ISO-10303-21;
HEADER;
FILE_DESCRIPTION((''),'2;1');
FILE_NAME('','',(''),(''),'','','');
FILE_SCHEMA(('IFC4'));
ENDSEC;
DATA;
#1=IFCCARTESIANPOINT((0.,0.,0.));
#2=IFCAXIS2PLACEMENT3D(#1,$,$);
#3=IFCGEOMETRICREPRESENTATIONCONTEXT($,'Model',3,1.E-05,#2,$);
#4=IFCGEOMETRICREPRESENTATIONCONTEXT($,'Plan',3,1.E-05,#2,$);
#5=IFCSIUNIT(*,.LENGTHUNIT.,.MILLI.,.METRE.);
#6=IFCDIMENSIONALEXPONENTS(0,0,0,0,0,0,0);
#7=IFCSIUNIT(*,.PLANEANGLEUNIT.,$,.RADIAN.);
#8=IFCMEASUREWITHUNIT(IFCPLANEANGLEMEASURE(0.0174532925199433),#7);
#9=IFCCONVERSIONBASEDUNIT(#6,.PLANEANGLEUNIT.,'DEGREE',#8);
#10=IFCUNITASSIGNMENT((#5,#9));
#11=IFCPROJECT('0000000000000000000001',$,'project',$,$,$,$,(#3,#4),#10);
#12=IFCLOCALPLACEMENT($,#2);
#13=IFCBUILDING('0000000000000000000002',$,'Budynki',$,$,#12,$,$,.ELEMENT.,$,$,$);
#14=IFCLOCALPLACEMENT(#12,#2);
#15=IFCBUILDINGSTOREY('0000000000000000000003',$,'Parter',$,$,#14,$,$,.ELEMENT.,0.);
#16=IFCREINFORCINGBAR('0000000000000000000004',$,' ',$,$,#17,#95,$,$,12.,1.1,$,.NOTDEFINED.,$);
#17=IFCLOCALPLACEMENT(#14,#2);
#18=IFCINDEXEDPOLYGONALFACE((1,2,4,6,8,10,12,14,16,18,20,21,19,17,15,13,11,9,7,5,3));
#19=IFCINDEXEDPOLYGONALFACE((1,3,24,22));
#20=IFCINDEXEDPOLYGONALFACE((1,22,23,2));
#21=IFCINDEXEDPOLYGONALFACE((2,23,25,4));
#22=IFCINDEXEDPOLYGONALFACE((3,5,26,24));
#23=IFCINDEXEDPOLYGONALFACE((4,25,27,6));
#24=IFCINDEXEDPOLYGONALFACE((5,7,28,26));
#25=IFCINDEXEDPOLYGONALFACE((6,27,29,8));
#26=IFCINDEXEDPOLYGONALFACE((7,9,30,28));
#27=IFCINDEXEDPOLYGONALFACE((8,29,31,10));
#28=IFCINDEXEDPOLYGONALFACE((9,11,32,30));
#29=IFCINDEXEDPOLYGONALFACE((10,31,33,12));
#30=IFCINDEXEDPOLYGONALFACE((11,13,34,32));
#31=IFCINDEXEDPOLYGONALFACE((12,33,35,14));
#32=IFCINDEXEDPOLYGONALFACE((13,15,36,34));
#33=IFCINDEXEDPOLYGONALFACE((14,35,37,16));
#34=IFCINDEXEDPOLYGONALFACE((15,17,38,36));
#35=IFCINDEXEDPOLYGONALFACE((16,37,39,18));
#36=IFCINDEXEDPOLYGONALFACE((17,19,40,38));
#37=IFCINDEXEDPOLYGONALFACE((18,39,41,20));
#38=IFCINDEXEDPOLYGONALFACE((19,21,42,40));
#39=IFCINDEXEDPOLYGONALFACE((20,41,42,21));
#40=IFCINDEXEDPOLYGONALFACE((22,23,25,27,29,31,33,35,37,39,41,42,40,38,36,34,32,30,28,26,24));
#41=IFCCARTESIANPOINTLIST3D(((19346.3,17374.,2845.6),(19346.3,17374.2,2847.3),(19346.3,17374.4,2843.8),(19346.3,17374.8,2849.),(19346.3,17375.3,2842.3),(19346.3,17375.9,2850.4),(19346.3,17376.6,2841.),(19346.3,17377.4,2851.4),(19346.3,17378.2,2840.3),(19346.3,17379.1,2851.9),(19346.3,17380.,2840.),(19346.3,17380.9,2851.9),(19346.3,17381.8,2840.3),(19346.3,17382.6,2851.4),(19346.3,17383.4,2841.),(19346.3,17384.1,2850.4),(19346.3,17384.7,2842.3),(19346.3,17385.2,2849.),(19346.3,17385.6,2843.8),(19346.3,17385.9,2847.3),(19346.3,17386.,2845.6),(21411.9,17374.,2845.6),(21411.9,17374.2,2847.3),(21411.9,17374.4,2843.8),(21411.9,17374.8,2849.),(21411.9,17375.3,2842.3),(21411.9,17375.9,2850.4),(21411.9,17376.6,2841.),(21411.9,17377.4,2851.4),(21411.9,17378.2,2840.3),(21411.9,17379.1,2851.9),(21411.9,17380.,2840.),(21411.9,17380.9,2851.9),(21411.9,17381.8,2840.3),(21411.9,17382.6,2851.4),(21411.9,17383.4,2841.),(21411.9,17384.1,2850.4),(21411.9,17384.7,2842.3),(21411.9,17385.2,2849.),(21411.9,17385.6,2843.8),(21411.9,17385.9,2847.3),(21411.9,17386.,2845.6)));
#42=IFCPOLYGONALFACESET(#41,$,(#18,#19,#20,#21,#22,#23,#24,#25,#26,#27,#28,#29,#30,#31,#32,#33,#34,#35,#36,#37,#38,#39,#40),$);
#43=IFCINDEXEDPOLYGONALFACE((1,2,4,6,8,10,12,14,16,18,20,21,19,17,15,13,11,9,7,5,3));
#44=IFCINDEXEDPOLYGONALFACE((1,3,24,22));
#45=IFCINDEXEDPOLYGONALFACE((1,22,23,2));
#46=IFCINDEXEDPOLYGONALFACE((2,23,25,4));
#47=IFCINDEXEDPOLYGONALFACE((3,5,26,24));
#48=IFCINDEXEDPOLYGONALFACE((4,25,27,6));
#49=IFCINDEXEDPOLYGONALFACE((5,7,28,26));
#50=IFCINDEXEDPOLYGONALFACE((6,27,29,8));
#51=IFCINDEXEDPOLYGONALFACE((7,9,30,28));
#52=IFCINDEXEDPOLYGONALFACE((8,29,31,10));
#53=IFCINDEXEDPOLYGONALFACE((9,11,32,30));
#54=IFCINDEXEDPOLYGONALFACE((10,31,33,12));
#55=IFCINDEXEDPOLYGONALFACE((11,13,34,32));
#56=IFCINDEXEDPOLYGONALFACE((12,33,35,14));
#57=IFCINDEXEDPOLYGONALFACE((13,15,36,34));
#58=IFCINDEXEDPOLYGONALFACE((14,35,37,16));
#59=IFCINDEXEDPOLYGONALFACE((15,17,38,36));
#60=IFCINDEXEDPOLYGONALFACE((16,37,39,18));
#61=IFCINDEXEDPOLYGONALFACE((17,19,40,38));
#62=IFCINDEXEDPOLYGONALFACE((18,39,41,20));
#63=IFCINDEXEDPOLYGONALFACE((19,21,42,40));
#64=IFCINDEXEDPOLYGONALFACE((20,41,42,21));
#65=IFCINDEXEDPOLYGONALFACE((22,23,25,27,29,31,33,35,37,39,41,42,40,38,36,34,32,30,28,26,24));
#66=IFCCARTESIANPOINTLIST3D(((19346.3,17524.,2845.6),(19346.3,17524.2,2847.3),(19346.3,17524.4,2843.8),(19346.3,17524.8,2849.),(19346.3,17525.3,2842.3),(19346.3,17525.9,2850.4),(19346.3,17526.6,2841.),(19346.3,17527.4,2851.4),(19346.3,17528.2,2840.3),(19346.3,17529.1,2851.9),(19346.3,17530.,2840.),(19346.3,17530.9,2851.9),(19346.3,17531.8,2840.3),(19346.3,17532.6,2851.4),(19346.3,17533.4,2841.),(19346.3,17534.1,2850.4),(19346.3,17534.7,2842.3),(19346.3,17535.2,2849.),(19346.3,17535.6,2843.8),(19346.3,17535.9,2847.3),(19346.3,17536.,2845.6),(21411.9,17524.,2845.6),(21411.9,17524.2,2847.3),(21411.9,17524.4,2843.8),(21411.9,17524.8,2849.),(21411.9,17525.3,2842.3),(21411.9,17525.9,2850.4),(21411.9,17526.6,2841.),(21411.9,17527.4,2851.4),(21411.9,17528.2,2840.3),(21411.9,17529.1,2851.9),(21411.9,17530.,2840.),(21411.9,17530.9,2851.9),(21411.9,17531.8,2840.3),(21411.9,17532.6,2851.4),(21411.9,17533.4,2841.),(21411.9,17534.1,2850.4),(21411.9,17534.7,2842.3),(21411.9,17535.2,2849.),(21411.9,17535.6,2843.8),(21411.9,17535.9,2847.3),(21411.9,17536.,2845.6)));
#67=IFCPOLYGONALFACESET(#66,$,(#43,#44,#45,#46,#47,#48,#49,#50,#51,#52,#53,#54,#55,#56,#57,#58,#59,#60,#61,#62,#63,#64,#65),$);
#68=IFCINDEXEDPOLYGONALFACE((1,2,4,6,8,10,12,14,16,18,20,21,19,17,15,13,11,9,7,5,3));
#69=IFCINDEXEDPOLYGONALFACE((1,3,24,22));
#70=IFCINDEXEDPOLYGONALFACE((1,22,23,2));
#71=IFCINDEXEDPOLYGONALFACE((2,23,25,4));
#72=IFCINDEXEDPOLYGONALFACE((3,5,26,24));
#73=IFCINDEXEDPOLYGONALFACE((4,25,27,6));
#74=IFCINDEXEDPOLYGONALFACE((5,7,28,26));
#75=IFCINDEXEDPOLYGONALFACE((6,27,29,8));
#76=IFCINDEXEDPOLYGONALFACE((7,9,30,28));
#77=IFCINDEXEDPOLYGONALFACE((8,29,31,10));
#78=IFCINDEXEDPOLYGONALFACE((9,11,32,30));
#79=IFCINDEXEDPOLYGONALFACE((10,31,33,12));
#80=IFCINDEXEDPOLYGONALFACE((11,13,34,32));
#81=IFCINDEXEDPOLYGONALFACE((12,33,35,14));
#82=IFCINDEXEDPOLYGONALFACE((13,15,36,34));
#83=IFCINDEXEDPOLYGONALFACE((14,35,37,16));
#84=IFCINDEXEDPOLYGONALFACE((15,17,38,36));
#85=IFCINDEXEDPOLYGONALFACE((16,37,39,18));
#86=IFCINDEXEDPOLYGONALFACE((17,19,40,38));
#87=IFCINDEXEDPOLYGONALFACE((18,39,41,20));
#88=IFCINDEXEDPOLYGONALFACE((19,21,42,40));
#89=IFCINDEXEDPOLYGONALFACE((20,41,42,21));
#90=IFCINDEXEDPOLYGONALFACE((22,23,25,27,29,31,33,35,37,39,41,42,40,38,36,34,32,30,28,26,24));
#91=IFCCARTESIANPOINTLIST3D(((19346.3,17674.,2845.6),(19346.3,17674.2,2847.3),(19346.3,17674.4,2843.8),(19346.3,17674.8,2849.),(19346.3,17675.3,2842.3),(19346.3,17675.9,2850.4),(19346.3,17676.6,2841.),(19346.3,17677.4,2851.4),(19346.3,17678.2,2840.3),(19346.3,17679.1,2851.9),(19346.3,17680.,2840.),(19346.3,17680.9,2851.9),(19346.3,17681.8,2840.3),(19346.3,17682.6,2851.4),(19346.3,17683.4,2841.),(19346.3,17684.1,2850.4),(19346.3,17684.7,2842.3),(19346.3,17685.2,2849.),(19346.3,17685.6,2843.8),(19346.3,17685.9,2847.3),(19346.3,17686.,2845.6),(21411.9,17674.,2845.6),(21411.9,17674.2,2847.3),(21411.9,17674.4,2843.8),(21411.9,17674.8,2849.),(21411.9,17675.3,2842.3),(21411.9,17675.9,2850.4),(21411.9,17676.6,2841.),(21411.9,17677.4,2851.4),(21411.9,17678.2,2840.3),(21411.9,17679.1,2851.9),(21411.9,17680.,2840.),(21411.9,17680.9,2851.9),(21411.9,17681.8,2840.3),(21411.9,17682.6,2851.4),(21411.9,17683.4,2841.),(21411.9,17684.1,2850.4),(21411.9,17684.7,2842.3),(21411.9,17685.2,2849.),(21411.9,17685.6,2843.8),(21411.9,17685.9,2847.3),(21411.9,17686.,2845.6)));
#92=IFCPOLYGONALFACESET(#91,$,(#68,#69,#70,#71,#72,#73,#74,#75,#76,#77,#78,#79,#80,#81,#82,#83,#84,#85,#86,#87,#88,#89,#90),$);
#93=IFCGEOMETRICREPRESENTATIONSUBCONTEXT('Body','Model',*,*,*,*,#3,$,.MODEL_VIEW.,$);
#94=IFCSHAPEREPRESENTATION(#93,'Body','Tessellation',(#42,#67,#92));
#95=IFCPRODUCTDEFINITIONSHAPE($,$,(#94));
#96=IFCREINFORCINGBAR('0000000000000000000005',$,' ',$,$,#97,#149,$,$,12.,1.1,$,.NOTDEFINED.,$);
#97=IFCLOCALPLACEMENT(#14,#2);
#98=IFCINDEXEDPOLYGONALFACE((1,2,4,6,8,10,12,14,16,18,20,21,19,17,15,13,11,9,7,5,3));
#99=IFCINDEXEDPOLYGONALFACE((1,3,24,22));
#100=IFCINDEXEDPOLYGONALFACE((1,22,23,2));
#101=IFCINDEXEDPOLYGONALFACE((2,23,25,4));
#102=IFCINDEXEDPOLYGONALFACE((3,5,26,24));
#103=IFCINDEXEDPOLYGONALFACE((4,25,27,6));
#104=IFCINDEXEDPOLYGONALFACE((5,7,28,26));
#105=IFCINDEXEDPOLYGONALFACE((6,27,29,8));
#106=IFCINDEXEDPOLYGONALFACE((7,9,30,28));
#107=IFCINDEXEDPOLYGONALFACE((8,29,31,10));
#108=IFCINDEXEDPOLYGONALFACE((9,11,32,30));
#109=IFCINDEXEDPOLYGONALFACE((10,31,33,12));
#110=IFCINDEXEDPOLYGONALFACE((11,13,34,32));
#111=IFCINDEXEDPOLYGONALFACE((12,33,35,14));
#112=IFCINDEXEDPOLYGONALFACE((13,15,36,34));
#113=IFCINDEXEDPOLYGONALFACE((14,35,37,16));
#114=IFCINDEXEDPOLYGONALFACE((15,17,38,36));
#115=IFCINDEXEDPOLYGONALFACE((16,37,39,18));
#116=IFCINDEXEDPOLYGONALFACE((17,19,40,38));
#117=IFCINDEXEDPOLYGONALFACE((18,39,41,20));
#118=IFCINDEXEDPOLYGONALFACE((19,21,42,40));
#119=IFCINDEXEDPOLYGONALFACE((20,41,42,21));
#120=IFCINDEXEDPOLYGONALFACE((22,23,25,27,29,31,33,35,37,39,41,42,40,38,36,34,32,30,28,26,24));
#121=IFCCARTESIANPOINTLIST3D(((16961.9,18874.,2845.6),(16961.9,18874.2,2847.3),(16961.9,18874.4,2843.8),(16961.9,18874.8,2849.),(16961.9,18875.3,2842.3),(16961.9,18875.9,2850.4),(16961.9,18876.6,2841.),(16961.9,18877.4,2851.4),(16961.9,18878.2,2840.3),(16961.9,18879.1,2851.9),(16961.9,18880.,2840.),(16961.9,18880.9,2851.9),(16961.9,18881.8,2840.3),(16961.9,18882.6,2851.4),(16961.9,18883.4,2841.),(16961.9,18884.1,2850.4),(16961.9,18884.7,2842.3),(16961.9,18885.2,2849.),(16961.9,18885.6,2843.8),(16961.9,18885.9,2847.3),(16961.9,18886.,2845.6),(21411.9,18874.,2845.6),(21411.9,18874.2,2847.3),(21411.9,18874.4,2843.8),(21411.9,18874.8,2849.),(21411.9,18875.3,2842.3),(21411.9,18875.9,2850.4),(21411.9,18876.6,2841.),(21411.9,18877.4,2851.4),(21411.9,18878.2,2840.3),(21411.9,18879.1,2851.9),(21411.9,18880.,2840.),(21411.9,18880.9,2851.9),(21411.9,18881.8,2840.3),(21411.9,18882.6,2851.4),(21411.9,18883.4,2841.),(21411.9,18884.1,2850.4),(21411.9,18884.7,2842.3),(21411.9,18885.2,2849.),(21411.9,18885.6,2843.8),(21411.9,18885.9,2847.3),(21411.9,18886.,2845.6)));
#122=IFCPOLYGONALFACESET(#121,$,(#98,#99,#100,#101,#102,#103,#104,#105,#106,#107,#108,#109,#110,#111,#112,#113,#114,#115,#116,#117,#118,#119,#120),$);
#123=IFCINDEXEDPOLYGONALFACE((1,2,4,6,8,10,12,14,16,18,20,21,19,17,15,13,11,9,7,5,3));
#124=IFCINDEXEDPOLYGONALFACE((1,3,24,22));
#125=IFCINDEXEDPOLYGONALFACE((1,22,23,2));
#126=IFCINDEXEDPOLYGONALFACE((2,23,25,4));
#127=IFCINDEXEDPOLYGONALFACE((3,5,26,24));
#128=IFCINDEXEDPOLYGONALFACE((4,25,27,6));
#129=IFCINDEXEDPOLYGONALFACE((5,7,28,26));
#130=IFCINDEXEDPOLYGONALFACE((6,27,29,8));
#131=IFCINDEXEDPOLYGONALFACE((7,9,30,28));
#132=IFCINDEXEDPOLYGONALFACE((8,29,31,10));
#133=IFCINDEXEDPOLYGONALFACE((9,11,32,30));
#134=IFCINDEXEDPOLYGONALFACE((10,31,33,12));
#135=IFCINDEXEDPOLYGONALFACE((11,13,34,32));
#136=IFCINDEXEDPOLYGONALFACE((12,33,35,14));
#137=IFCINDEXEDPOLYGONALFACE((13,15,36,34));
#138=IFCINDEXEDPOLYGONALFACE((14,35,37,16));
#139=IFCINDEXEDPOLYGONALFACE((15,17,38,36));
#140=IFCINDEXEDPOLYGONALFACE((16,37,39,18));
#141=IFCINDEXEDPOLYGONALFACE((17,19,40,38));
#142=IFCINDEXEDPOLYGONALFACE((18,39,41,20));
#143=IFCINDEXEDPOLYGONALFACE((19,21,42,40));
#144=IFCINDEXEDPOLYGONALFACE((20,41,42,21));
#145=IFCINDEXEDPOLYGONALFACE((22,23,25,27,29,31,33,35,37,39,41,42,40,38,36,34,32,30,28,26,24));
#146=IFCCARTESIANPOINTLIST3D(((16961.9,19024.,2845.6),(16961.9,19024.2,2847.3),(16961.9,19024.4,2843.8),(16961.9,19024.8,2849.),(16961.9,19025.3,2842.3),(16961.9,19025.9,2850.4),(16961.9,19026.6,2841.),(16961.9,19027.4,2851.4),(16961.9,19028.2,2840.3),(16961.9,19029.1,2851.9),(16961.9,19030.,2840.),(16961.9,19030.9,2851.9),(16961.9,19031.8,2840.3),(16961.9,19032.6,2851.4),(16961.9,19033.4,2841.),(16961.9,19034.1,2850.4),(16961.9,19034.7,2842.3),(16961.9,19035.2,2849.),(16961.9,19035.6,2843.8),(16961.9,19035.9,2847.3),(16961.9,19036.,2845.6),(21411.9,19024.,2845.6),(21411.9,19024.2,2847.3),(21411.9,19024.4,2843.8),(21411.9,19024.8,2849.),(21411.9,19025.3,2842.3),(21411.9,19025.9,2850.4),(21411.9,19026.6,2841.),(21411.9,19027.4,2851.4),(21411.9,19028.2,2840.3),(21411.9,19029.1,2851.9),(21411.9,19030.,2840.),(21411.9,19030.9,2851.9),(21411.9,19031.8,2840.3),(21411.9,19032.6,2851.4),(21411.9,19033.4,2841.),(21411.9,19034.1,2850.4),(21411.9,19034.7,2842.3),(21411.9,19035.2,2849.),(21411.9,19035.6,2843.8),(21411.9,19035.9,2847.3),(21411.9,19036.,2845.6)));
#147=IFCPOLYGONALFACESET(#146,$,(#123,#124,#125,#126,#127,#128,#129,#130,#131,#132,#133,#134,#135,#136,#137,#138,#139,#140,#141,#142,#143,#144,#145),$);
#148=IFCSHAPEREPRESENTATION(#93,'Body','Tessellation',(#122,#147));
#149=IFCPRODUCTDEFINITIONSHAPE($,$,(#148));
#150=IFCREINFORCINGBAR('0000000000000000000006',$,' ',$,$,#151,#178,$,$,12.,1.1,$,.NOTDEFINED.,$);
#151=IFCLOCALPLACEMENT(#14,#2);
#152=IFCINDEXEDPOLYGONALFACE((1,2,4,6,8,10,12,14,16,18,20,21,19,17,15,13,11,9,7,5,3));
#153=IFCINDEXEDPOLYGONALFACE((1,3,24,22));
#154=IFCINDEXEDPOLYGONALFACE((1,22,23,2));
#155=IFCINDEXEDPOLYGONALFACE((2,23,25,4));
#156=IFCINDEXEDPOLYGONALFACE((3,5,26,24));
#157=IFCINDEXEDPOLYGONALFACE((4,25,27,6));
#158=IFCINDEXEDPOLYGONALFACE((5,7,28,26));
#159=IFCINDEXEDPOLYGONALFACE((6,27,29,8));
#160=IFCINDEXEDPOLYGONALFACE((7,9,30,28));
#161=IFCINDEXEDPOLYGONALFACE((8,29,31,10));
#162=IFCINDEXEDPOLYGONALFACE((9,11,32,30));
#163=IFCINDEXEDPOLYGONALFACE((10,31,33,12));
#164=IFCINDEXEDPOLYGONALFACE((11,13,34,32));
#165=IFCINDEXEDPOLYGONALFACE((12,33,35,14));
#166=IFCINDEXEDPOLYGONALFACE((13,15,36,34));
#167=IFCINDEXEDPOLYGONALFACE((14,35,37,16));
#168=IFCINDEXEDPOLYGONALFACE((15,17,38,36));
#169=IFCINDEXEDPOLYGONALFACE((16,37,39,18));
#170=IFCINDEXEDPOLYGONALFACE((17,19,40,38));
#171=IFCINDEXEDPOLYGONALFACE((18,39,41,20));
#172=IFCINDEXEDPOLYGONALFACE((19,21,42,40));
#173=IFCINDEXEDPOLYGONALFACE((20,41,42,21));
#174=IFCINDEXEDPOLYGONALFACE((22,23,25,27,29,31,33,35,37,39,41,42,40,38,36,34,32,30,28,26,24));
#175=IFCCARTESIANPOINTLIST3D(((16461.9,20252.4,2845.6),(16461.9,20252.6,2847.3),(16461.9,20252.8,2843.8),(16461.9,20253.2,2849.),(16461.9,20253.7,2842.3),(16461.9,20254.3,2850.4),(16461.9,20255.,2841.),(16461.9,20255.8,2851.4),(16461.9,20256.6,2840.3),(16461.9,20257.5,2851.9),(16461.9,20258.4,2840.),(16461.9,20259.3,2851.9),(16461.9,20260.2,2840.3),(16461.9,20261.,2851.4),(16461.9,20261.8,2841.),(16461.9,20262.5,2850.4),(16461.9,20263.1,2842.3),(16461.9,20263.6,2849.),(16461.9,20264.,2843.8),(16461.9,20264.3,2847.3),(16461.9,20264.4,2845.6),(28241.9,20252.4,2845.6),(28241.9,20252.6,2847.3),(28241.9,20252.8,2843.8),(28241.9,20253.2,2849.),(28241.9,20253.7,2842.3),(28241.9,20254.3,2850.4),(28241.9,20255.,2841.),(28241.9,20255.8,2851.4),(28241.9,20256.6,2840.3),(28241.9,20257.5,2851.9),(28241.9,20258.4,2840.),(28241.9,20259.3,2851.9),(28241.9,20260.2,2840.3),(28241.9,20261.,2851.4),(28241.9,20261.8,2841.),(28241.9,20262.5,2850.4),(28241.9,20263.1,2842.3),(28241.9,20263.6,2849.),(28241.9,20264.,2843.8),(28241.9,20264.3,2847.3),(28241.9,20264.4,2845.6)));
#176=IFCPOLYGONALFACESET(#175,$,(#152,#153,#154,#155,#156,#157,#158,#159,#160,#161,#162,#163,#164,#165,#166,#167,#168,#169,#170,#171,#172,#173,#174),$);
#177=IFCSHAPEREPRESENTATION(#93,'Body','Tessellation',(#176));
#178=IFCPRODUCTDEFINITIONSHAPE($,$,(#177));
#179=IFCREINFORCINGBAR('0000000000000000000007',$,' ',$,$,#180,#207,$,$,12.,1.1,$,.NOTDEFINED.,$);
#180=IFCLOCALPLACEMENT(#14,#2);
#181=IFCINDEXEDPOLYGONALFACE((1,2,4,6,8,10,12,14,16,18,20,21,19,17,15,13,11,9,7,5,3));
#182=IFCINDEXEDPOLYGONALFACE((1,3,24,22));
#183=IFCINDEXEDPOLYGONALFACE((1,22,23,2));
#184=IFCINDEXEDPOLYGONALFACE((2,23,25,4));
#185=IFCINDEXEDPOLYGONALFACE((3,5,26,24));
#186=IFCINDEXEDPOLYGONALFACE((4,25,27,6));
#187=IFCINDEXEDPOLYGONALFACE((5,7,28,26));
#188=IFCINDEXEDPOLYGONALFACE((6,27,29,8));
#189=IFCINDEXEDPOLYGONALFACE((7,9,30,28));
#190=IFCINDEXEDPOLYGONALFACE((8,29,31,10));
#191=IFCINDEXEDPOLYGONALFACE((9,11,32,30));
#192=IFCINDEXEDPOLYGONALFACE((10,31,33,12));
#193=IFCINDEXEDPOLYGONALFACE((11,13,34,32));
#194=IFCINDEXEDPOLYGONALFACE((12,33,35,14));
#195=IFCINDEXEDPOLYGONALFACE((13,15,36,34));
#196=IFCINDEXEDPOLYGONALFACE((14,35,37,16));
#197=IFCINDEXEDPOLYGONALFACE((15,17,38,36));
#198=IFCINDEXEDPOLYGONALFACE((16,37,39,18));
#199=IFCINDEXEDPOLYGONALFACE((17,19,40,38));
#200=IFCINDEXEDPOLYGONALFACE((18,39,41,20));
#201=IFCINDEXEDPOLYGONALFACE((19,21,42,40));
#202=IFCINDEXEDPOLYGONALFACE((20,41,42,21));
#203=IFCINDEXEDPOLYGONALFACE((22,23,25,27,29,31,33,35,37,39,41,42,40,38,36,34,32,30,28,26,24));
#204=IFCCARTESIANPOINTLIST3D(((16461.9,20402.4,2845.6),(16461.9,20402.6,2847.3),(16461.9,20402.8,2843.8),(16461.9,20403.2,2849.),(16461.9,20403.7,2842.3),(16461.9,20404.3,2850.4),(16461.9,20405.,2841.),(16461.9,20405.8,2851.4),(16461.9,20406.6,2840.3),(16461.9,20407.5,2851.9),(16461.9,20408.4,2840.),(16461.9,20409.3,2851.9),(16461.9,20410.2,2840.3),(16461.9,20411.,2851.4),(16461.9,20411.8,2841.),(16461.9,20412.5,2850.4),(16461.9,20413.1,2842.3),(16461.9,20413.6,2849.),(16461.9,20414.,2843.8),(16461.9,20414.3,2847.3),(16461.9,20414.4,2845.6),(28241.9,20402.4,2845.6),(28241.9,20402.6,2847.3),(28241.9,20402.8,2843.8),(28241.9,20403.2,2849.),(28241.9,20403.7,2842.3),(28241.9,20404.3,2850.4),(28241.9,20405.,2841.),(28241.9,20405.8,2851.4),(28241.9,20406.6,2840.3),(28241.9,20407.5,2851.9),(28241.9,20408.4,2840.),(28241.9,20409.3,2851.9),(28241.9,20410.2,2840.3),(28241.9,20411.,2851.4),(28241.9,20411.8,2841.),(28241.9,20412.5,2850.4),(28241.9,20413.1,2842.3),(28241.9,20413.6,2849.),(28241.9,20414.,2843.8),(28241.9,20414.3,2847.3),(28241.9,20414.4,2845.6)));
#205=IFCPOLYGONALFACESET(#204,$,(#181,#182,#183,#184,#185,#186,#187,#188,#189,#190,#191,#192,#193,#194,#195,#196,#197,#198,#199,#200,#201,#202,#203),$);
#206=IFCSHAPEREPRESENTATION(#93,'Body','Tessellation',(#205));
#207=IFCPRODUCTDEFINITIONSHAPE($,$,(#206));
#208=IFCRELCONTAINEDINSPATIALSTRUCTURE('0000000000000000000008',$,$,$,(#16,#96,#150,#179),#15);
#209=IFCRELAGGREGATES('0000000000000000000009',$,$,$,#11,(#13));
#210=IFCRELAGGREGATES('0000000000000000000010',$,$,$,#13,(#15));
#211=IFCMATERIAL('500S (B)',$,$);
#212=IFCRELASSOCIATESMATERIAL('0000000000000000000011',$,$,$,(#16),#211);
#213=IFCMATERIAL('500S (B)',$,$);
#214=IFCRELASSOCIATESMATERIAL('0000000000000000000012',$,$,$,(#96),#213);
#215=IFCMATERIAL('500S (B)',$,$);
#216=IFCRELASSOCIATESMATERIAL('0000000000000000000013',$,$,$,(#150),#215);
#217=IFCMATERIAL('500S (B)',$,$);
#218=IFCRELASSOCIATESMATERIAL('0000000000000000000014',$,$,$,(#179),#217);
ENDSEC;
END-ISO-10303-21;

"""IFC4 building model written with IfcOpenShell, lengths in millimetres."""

from ifc_helpers import new_model, entity, si_unit, converted_unit, frame, origin, place, context, subcontext, project, spatial, material, element, save


model = new_model("IFC4")

# Units and contexts
model_context = context("Model", 3, precision=1e-05, world=origin())
plan_context = context("Plan", 3, precision=1e-05, world=origin())
body_context = subcontext(model_context, "Body", "Model", "MODEL_VIEW")
ifc_project = project(units=[si_unit("LENGTHUNIT", "METRE", prefix="MILLI"), converted_unit("PLANEANGLEUNIT", "DEGREE", entity("IfcPlaneAngleMeasure", 0.0174532925199433), si_unit("PLANEANGLEUNIT", "RADIAN"), dimensions=[0, 0, 0, 0, 0, 0, 0])], contexts=[model_context, plan_context])

# Building, storey
building_placement = place(None, origin())
building = spatial("IfcBuilding", under=ifc_project, at=building_placement, Name="Budynki", CompositionType="ELEMENT")
storey_placement = place(building_placement, origin())
storey = spatial("IfcBuildingStorey", under=building, at=storey_placement, Name="Parter", CompositionType="ELEMENT", Elevation=0.0)

# Reinforcing bars
ifc_material_1 = material(Name="500S (B)")
reinforcing_bar_1_placement = place(storey_placement, frame((21411.9, 17380.0, 2846.0)))
element("IfcReinforcingBar", 1, at=reinforcing_bar_1_placement, inside=storey, material=ifc_material_1, Name=" ", CrossSectionArea=1.1, NominalDiameter=12.0, PredefinedType="NOTDEFINED", context=body_context, shape_type="AdvancedSweptSolid", body=[
    entity("IfcSweptDiskSolid", entity("IfcPolyline", [entity("IfcCartesianPoint", [0.0, 0.0, 0.0]), entity("IfcCartesianPoint", [-2065.6, 0.0, 0.0])]), 6.0, None, 0.0, 1.0),
    entity("IfcSweptDiskSolid", entity("IfcPolyline", [entity("IfcCartesianPoint", [0.0, 150.0, 0.0]), entity("IfcCartesianPoint", [-2065.6, 150.0, 0.0])]), 6.0, None, 0.0, 1.0),
    entity("IfcSweptDiskSolid", entity("IfcPolyline", [entity("IfcCartesianPoint", [0.0, 300.0, 0.0]), entity("IfcCartesianPoint", [-2065.6, 300.0, 0.0])]), 6.0, None, 0.0, 1.0),
])
ifc_material_2 = material(Name="500S (B)")
reinforcing_bar_2_placement = place(storey_placement, frame((21411.9, 18880.0, 2846.0)))
element("IfcReinforcingBar", 2, at=reinforcing_bar_2_placement, inside=storey, material=ifc_material_2, Name=" ", CrossSectionArea=1.1, NominalDiameter=12.0, PredefinedType="NOTDEFINED", context=body_context, shape_type="AdvancedSweptSolid", body=[
    entity("IfcSweptDiskSolid", entity("IfcPolyline", [entity("IfcCartesianPoint", [0.0, 0.0, 0.0]), entity("IfcCartesianPoint", [-4450.0, 0.0, 0.0])]), 6.0, None, 0.0, 1.0),
    entity("IfcSweptDiskSolid", entity("IfcPolyline", [entity("IfcCartesianPoint", [0.0, 150.0, 0.0]), entity("IfcCartesianPoint", [-4450.0, 150.0, 0.0])]), 6.0, None, 0.0, 1.0),
])
ifc_material_3 = material(Name="500S (B)")
reinforcing_bar_3_placement = place(storey_placement, frame((28241.9, 20258.4, 2846.0)))
element("IfcReinforcingBar", 3, at=reinforcing_bar_3_placement, inside=storey, material=ifc_material_3, Name=" ", CrossSectionArea=1.1, NominalDiameter=12.0, PredefinedType="NOTDEFINED", context=body_context, shape_type="AdvancedSweptSolid", body=[
    entity("IfcSweptDiskSolid", entity("IfcPolyline", [entity("IfcCartesianPoint", [0.0, 0.0, 0.0]), entity("IfcCartesianPoint", [-11780.0, 0.0, 0.0])]), 6.0, None, 0.0, 1.0),
])
ifc_material_4 = material(Name="500S (B)")
reinforcing_bar_4_placement = place(storey_placement, frame((28241.9, 20408.4, 2846.0)))
element("IfcReinforcingBar", 4, at=reinforcing_bar_4_placement, inside=storey, material=ifc_material_4, Name=" ", CrossSectionArea=1.1, NominalDiameter=12.0, PredefinedType="NOTDEFINED", context=body_context, shape_type="AdvancedSweptSolid", body=[
    entity("IfcSweptDiskSolid", entity("IfcPolyline", [entity("IfcCartesianPoint", [0.0, 0.0, 0.0]), entity("IfcCartesianPoint", [-11780.0, 0.0, 0.0])]), 6.0, None, 0.0, 1.0),
])

save(model, "model.ifc")
